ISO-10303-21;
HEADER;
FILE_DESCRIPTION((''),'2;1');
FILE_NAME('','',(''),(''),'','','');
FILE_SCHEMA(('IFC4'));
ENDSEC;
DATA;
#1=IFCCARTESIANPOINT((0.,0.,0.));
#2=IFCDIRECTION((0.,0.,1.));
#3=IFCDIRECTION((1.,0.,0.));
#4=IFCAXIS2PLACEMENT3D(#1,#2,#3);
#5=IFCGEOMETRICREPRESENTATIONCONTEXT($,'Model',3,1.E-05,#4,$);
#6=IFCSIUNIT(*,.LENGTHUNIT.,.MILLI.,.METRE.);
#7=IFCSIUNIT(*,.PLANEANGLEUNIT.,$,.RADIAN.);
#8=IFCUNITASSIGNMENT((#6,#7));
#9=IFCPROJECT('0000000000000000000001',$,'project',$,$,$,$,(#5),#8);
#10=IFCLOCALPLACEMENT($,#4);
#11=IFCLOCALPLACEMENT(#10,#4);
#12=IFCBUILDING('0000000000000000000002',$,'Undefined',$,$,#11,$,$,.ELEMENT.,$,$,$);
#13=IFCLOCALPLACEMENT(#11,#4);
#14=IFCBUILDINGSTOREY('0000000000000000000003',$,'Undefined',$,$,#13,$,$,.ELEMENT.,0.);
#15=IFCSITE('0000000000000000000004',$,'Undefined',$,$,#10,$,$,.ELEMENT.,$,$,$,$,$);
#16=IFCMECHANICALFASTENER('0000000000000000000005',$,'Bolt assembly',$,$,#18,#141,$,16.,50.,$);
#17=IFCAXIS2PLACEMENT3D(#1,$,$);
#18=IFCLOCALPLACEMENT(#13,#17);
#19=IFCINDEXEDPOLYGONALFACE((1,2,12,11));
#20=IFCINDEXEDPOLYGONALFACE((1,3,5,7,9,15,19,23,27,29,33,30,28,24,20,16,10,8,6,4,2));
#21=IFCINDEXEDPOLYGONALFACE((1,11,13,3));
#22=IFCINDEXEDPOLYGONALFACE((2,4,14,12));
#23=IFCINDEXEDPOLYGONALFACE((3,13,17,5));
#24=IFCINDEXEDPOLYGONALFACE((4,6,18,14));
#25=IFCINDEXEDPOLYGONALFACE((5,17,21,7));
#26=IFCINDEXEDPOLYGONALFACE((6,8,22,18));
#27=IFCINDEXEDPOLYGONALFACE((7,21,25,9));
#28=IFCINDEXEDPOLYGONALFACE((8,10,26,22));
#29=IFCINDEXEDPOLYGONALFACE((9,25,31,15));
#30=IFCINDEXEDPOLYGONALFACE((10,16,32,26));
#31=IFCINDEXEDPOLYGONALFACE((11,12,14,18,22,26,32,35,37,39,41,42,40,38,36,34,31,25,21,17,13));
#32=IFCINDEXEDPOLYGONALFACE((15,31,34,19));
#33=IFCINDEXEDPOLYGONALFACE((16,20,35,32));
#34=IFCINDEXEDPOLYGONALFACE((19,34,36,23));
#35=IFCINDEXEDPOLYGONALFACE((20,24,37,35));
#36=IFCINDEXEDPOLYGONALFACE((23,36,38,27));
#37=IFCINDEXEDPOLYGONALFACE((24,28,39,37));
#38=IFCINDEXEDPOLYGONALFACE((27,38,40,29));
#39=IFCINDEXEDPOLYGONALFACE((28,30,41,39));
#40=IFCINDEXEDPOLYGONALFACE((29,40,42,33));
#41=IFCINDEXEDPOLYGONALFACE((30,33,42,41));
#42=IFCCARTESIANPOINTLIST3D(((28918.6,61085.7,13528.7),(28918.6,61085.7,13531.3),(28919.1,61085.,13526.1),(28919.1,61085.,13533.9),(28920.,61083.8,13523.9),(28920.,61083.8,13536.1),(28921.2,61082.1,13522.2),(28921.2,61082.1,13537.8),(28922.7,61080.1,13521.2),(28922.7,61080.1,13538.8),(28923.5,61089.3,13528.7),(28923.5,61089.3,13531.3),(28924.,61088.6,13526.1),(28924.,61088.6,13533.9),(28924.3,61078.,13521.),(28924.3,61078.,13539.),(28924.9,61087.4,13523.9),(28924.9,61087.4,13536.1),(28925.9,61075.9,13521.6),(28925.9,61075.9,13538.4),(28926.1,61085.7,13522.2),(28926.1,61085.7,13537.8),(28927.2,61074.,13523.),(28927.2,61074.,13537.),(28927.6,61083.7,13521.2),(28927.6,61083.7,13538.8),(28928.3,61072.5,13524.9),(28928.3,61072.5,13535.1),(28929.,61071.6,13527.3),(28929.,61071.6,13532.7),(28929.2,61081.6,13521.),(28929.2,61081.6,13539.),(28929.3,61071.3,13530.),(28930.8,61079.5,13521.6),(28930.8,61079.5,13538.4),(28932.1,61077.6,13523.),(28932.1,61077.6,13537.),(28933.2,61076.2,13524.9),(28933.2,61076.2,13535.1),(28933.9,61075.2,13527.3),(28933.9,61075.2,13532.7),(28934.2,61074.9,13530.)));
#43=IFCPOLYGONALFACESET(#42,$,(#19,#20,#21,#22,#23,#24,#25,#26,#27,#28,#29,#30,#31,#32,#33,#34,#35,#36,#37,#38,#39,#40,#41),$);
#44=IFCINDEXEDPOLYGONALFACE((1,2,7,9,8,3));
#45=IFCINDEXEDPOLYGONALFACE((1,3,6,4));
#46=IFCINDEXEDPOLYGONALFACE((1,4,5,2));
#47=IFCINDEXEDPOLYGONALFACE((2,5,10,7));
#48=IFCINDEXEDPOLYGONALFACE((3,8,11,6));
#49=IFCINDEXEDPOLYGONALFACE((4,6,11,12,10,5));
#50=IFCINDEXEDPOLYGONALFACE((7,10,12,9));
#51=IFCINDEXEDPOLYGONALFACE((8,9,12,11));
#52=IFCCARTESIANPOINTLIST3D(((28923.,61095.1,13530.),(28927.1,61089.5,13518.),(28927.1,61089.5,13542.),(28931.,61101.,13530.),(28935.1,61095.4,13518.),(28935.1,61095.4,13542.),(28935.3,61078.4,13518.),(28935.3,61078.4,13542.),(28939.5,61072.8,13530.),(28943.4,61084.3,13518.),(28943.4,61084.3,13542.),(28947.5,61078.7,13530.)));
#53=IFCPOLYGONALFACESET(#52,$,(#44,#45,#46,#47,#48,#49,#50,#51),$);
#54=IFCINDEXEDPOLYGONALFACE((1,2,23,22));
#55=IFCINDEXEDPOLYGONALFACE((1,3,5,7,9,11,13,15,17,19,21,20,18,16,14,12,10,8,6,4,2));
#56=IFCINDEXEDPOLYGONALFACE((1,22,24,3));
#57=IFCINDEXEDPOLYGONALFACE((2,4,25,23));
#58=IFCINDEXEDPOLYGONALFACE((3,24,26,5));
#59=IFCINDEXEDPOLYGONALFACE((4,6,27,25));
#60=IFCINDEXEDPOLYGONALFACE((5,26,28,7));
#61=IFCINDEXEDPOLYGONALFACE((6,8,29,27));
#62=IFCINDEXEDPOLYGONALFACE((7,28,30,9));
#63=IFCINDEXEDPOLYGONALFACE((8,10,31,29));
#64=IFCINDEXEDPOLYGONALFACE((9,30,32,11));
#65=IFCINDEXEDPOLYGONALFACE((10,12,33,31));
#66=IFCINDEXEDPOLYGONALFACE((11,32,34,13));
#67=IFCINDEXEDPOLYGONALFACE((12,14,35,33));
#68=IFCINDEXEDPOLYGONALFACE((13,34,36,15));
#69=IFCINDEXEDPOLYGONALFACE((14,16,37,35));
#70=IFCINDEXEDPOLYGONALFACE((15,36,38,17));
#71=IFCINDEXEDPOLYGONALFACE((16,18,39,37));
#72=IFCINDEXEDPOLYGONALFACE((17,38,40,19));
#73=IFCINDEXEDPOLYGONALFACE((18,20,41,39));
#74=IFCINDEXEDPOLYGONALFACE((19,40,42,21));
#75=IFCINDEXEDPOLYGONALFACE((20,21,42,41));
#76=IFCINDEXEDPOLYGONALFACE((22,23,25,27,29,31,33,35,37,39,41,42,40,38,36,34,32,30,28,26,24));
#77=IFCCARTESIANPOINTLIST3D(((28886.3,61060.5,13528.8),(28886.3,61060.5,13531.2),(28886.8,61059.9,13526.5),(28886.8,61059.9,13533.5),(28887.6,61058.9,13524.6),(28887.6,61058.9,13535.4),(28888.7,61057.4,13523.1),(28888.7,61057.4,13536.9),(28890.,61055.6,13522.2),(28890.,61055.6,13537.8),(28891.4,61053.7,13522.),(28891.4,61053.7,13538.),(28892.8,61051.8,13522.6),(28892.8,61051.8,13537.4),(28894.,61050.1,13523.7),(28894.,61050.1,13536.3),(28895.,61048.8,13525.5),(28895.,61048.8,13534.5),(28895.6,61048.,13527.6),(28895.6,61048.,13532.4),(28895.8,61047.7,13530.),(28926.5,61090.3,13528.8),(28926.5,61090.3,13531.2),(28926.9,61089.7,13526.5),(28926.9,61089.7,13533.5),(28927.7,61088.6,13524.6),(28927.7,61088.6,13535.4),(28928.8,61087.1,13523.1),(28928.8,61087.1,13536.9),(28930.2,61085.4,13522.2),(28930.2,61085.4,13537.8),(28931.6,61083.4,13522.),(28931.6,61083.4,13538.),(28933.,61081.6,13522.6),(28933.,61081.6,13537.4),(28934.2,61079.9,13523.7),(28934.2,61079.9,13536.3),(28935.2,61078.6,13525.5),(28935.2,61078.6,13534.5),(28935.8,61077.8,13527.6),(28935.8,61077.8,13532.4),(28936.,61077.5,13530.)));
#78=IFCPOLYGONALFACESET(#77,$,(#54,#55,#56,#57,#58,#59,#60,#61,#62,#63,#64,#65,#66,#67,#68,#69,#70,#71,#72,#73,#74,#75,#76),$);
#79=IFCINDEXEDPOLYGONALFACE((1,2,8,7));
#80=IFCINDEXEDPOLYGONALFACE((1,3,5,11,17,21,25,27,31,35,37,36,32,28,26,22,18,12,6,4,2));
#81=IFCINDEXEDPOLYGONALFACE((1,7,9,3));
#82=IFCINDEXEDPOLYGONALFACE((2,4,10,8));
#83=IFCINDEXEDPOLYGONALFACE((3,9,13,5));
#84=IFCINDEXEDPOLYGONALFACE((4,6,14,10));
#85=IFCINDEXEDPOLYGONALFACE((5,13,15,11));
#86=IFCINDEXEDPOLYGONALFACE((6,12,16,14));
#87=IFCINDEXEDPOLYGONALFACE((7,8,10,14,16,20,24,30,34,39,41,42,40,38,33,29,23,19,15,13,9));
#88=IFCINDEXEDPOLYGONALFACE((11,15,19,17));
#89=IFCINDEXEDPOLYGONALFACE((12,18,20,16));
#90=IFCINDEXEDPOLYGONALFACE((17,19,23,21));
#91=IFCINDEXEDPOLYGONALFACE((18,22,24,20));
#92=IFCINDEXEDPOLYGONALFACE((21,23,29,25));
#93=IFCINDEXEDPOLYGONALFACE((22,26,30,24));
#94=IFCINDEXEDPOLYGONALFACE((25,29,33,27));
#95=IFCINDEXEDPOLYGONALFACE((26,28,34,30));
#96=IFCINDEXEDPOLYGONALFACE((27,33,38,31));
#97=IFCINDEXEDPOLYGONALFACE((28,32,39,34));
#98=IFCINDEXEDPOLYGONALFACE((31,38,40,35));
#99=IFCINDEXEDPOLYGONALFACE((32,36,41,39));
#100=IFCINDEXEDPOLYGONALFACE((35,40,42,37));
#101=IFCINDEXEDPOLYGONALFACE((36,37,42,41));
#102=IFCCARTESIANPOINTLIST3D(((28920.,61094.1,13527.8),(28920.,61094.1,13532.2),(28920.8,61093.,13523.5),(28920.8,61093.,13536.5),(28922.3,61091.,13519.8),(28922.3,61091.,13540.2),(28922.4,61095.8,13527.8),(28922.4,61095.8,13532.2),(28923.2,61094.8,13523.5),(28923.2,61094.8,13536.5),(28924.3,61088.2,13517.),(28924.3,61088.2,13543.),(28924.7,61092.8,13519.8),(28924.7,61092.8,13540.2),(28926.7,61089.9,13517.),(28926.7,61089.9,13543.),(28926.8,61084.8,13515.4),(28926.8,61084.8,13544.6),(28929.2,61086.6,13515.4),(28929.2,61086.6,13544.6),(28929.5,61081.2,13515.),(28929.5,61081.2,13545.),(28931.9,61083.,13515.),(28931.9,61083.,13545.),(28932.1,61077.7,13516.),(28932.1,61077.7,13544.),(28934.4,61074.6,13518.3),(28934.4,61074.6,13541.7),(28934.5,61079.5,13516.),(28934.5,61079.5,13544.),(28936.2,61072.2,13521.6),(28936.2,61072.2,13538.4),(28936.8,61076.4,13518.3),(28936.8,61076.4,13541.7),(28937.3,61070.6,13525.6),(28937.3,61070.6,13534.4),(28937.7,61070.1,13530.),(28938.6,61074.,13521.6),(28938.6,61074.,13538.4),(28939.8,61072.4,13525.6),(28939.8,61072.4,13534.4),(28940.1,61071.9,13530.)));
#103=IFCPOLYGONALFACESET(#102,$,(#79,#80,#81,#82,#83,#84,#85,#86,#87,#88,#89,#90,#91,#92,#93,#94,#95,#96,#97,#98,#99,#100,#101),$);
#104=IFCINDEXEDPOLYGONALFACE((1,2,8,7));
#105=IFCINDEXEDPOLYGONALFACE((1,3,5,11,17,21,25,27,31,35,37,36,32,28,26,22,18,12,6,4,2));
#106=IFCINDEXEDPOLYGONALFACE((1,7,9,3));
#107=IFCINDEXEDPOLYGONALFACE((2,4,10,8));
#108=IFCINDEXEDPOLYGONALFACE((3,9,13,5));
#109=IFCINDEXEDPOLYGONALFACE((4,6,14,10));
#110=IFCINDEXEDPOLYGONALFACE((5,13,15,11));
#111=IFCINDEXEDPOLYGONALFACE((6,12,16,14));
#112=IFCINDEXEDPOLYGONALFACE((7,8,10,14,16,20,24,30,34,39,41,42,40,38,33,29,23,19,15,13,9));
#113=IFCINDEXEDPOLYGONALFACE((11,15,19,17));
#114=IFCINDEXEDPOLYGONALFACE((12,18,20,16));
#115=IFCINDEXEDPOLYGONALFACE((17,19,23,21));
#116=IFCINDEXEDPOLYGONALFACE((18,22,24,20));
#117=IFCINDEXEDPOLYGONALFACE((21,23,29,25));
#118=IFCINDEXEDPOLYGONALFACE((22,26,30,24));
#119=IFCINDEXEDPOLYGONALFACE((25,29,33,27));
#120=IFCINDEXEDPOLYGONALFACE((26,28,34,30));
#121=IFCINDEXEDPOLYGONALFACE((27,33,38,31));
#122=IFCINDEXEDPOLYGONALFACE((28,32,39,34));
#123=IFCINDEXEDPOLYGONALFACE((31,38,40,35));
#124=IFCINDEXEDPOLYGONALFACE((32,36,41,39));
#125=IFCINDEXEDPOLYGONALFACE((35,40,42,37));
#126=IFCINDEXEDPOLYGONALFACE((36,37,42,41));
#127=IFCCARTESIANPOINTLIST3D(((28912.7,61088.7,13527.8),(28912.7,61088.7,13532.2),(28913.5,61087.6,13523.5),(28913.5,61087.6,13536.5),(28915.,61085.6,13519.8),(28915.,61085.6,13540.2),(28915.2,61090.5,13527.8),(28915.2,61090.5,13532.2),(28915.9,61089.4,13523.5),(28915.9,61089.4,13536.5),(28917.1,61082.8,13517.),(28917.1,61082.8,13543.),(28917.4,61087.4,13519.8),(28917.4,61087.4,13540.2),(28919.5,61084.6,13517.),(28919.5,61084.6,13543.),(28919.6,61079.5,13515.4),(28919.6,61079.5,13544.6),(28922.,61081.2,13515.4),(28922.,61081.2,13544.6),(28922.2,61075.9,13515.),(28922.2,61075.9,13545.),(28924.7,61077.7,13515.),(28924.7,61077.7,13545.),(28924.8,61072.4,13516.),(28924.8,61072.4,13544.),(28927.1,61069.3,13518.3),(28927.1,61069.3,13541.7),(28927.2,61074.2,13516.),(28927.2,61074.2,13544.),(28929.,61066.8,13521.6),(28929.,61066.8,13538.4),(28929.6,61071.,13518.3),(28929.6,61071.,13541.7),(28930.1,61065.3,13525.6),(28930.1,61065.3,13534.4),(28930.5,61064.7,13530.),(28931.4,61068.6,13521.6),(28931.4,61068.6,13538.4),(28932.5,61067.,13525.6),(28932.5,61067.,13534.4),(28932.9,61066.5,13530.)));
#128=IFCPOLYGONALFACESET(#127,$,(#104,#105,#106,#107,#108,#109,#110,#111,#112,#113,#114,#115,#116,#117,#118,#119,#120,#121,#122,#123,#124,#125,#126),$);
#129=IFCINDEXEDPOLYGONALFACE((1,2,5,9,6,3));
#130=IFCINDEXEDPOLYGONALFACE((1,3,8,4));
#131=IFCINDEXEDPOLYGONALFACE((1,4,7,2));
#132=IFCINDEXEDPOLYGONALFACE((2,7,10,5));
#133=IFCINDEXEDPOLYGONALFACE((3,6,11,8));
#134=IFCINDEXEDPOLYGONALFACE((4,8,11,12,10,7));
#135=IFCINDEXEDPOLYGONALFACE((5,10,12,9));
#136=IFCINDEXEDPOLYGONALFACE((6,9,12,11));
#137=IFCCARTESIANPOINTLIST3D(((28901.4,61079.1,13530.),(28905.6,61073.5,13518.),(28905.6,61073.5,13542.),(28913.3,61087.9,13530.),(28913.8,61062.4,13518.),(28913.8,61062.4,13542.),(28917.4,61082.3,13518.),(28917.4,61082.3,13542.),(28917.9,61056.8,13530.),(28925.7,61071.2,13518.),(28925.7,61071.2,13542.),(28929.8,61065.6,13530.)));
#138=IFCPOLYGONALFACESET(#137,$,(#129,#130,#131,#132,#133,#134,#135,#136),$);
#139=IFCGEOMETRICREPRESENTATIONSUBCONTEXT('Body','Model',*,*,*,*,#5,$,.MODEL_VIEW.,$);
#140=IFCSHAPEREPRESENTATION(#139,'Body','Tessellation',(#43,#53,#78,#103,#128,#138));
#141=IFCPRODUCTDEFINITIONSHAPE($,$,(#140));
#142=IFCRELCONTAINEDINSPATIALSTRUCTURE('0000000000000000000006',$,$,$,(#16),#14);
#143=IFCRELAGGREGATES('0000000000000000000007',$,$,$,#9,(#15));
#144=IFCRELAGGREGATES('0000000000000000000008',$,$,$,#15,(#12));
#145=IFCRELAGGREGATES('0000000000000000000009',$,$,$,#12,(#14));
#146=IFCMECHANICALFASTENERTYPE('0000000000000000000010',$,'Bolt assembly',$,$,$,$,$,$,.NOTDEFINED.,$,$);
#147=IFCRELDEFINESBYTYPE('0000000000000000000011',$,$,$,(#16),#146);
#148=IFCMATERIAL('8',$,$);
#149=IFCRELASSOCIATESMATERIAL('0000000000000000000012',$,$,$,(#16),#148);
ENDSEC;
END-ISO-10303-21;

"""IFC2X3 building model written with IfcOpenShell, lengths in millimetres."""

from ifc_helpers import new_model, si_unit, frame, origin_with_axes, origin_2d_with_axis, place, context, subcontext, project, spatial, polyline, circle, outline, extrude, source, transform, mapped, material, type_object, element, save


model = new_model("IFC2X3")

# Units and contexts
model_context = context("Model", 3, precision=1e-05, world=origin_with_axes())
body_context = subcontext(model_context, "Body", "Model", "MODEL_VIEW")
ifc_project = project(units=[si_unit("LENGTHUNIT", "METRE", prefix="MILLI"), si_unit("PLANEANGLEUNIT", "RADIAN")], contexts=[model_context])

# Site, building, storey
site_placement = place(None, origin_with_axes())
site = spatial("IfcSite", under=ifc_project, at=site_placement, Name="Undefined", CompositionType="ELEMENT")
building_placement = place(site_placement, origin_with_axes())
building = spatial("IfcBuilding", under=site, at=building_placement, Name="Undefined", CompositionType="ELEMENT")
storey_placement = place(building_placement, origin_with_axes())
storey = spatial("IfcBuildingStorey", under=building, at=storey_placement, Name="Undefined", CompositionType="ELEMENT", Elevation=0.0)

# Mechanical fastener
ifc_material_1 = material(Name="8")
mechanical_fastener_type = type_object("IfcMechanicalFastenerType", Name="Bolt assembly")
shared_shape_1 = source(origin_with_axes(), body_context, "Body", "SweptSolid", [
    extrude(circle(Radius=9.0, at=origin_2d_with_axis()), frame((0.0, -6.0, 0.0), z_axis=(0.0, 1.0, 0.0), x_axis=(1.0, 0.0, 0.0)), (0.0, 0.0, 1.0), 6.1),
    extrude(outline(polyline([(13.9, 0.0), (6.9, 12.0), (-6.9, 12.0), (-13.9, 0.0), (-6.9, -12.0), (6.9, -12.0), (13.9, 0.0)])), frame((0.0, -19.0, 0.0), z_axis=(0.0, 1.0, 0.0), x_axis=(1.0, 0.0, 0.0)), (0.0, 0.0, 1.0), 10.0),
    extrude(circle(Radius=8.0, at=origin_2d_with_axis()), frame((0.0, -9.0, 0.0), z_axis=(0.0, 1.0, 0.0), x_axis=(1.0, 0.0, 0.0)), (0.0, 0.0, 1.0), 50.0),
    extrude(circle(Radius=15.0, at=origin_2d_with_axis()), frame((0.0, -9.0, 0.0), z_axis=(0.0, 1.0, 0.0), x_axis=(1.0, 0.0, 0.0)), (0.0, 0.0, 1.0), 3.0),
    extrude(circle(Radius=15.0, at=origin_2d_with_axis()), frame((0.0, 0.0, 0.0), z_axis=(0.0, 1.0, 0.0), x_axis=(1.0, 0.0, 0.0)), (0.0, 0.0, 1.0), 3.0),
    extrude(outline(polyline([(13.9, 0.0), (6.9, 12.0), (-6.9, 12.0), (-13.9, 0.0), (-6.9, -12.0), (6.9, -12.0), (13.9, 0.0)])), frame((0.0, 3.0, 0.0), z_axis=(0.0, 1.0, 0.0), x_axis=(1.0, 0.0, 0.0)), (0.0, 0.0, 1.0), 14.8),
])
mechanical_fastener_1_placement = place(storey_placement, frame((28924.0, 61078.6, 13530.0), z_axis=(0.0, 0.0, -1.0), x_axis=(0.595445, -0.803396, 0.0)))
element("IfcMechanicalFastener", 1, at=mechanical_fastener_1_placement, inside=storey, type_object=mechanical_fastener_type, material=ifc_material_1, Name="Bolt assembly", NominalDiameter=16.0, NominalLength=50.0, context=body_context, shape_type="MappedRepresentation", body=[
    mapped(shared_shape_1, transform((0.0, 0.0, 0.0))),
])

save(model, "model.ifc")
